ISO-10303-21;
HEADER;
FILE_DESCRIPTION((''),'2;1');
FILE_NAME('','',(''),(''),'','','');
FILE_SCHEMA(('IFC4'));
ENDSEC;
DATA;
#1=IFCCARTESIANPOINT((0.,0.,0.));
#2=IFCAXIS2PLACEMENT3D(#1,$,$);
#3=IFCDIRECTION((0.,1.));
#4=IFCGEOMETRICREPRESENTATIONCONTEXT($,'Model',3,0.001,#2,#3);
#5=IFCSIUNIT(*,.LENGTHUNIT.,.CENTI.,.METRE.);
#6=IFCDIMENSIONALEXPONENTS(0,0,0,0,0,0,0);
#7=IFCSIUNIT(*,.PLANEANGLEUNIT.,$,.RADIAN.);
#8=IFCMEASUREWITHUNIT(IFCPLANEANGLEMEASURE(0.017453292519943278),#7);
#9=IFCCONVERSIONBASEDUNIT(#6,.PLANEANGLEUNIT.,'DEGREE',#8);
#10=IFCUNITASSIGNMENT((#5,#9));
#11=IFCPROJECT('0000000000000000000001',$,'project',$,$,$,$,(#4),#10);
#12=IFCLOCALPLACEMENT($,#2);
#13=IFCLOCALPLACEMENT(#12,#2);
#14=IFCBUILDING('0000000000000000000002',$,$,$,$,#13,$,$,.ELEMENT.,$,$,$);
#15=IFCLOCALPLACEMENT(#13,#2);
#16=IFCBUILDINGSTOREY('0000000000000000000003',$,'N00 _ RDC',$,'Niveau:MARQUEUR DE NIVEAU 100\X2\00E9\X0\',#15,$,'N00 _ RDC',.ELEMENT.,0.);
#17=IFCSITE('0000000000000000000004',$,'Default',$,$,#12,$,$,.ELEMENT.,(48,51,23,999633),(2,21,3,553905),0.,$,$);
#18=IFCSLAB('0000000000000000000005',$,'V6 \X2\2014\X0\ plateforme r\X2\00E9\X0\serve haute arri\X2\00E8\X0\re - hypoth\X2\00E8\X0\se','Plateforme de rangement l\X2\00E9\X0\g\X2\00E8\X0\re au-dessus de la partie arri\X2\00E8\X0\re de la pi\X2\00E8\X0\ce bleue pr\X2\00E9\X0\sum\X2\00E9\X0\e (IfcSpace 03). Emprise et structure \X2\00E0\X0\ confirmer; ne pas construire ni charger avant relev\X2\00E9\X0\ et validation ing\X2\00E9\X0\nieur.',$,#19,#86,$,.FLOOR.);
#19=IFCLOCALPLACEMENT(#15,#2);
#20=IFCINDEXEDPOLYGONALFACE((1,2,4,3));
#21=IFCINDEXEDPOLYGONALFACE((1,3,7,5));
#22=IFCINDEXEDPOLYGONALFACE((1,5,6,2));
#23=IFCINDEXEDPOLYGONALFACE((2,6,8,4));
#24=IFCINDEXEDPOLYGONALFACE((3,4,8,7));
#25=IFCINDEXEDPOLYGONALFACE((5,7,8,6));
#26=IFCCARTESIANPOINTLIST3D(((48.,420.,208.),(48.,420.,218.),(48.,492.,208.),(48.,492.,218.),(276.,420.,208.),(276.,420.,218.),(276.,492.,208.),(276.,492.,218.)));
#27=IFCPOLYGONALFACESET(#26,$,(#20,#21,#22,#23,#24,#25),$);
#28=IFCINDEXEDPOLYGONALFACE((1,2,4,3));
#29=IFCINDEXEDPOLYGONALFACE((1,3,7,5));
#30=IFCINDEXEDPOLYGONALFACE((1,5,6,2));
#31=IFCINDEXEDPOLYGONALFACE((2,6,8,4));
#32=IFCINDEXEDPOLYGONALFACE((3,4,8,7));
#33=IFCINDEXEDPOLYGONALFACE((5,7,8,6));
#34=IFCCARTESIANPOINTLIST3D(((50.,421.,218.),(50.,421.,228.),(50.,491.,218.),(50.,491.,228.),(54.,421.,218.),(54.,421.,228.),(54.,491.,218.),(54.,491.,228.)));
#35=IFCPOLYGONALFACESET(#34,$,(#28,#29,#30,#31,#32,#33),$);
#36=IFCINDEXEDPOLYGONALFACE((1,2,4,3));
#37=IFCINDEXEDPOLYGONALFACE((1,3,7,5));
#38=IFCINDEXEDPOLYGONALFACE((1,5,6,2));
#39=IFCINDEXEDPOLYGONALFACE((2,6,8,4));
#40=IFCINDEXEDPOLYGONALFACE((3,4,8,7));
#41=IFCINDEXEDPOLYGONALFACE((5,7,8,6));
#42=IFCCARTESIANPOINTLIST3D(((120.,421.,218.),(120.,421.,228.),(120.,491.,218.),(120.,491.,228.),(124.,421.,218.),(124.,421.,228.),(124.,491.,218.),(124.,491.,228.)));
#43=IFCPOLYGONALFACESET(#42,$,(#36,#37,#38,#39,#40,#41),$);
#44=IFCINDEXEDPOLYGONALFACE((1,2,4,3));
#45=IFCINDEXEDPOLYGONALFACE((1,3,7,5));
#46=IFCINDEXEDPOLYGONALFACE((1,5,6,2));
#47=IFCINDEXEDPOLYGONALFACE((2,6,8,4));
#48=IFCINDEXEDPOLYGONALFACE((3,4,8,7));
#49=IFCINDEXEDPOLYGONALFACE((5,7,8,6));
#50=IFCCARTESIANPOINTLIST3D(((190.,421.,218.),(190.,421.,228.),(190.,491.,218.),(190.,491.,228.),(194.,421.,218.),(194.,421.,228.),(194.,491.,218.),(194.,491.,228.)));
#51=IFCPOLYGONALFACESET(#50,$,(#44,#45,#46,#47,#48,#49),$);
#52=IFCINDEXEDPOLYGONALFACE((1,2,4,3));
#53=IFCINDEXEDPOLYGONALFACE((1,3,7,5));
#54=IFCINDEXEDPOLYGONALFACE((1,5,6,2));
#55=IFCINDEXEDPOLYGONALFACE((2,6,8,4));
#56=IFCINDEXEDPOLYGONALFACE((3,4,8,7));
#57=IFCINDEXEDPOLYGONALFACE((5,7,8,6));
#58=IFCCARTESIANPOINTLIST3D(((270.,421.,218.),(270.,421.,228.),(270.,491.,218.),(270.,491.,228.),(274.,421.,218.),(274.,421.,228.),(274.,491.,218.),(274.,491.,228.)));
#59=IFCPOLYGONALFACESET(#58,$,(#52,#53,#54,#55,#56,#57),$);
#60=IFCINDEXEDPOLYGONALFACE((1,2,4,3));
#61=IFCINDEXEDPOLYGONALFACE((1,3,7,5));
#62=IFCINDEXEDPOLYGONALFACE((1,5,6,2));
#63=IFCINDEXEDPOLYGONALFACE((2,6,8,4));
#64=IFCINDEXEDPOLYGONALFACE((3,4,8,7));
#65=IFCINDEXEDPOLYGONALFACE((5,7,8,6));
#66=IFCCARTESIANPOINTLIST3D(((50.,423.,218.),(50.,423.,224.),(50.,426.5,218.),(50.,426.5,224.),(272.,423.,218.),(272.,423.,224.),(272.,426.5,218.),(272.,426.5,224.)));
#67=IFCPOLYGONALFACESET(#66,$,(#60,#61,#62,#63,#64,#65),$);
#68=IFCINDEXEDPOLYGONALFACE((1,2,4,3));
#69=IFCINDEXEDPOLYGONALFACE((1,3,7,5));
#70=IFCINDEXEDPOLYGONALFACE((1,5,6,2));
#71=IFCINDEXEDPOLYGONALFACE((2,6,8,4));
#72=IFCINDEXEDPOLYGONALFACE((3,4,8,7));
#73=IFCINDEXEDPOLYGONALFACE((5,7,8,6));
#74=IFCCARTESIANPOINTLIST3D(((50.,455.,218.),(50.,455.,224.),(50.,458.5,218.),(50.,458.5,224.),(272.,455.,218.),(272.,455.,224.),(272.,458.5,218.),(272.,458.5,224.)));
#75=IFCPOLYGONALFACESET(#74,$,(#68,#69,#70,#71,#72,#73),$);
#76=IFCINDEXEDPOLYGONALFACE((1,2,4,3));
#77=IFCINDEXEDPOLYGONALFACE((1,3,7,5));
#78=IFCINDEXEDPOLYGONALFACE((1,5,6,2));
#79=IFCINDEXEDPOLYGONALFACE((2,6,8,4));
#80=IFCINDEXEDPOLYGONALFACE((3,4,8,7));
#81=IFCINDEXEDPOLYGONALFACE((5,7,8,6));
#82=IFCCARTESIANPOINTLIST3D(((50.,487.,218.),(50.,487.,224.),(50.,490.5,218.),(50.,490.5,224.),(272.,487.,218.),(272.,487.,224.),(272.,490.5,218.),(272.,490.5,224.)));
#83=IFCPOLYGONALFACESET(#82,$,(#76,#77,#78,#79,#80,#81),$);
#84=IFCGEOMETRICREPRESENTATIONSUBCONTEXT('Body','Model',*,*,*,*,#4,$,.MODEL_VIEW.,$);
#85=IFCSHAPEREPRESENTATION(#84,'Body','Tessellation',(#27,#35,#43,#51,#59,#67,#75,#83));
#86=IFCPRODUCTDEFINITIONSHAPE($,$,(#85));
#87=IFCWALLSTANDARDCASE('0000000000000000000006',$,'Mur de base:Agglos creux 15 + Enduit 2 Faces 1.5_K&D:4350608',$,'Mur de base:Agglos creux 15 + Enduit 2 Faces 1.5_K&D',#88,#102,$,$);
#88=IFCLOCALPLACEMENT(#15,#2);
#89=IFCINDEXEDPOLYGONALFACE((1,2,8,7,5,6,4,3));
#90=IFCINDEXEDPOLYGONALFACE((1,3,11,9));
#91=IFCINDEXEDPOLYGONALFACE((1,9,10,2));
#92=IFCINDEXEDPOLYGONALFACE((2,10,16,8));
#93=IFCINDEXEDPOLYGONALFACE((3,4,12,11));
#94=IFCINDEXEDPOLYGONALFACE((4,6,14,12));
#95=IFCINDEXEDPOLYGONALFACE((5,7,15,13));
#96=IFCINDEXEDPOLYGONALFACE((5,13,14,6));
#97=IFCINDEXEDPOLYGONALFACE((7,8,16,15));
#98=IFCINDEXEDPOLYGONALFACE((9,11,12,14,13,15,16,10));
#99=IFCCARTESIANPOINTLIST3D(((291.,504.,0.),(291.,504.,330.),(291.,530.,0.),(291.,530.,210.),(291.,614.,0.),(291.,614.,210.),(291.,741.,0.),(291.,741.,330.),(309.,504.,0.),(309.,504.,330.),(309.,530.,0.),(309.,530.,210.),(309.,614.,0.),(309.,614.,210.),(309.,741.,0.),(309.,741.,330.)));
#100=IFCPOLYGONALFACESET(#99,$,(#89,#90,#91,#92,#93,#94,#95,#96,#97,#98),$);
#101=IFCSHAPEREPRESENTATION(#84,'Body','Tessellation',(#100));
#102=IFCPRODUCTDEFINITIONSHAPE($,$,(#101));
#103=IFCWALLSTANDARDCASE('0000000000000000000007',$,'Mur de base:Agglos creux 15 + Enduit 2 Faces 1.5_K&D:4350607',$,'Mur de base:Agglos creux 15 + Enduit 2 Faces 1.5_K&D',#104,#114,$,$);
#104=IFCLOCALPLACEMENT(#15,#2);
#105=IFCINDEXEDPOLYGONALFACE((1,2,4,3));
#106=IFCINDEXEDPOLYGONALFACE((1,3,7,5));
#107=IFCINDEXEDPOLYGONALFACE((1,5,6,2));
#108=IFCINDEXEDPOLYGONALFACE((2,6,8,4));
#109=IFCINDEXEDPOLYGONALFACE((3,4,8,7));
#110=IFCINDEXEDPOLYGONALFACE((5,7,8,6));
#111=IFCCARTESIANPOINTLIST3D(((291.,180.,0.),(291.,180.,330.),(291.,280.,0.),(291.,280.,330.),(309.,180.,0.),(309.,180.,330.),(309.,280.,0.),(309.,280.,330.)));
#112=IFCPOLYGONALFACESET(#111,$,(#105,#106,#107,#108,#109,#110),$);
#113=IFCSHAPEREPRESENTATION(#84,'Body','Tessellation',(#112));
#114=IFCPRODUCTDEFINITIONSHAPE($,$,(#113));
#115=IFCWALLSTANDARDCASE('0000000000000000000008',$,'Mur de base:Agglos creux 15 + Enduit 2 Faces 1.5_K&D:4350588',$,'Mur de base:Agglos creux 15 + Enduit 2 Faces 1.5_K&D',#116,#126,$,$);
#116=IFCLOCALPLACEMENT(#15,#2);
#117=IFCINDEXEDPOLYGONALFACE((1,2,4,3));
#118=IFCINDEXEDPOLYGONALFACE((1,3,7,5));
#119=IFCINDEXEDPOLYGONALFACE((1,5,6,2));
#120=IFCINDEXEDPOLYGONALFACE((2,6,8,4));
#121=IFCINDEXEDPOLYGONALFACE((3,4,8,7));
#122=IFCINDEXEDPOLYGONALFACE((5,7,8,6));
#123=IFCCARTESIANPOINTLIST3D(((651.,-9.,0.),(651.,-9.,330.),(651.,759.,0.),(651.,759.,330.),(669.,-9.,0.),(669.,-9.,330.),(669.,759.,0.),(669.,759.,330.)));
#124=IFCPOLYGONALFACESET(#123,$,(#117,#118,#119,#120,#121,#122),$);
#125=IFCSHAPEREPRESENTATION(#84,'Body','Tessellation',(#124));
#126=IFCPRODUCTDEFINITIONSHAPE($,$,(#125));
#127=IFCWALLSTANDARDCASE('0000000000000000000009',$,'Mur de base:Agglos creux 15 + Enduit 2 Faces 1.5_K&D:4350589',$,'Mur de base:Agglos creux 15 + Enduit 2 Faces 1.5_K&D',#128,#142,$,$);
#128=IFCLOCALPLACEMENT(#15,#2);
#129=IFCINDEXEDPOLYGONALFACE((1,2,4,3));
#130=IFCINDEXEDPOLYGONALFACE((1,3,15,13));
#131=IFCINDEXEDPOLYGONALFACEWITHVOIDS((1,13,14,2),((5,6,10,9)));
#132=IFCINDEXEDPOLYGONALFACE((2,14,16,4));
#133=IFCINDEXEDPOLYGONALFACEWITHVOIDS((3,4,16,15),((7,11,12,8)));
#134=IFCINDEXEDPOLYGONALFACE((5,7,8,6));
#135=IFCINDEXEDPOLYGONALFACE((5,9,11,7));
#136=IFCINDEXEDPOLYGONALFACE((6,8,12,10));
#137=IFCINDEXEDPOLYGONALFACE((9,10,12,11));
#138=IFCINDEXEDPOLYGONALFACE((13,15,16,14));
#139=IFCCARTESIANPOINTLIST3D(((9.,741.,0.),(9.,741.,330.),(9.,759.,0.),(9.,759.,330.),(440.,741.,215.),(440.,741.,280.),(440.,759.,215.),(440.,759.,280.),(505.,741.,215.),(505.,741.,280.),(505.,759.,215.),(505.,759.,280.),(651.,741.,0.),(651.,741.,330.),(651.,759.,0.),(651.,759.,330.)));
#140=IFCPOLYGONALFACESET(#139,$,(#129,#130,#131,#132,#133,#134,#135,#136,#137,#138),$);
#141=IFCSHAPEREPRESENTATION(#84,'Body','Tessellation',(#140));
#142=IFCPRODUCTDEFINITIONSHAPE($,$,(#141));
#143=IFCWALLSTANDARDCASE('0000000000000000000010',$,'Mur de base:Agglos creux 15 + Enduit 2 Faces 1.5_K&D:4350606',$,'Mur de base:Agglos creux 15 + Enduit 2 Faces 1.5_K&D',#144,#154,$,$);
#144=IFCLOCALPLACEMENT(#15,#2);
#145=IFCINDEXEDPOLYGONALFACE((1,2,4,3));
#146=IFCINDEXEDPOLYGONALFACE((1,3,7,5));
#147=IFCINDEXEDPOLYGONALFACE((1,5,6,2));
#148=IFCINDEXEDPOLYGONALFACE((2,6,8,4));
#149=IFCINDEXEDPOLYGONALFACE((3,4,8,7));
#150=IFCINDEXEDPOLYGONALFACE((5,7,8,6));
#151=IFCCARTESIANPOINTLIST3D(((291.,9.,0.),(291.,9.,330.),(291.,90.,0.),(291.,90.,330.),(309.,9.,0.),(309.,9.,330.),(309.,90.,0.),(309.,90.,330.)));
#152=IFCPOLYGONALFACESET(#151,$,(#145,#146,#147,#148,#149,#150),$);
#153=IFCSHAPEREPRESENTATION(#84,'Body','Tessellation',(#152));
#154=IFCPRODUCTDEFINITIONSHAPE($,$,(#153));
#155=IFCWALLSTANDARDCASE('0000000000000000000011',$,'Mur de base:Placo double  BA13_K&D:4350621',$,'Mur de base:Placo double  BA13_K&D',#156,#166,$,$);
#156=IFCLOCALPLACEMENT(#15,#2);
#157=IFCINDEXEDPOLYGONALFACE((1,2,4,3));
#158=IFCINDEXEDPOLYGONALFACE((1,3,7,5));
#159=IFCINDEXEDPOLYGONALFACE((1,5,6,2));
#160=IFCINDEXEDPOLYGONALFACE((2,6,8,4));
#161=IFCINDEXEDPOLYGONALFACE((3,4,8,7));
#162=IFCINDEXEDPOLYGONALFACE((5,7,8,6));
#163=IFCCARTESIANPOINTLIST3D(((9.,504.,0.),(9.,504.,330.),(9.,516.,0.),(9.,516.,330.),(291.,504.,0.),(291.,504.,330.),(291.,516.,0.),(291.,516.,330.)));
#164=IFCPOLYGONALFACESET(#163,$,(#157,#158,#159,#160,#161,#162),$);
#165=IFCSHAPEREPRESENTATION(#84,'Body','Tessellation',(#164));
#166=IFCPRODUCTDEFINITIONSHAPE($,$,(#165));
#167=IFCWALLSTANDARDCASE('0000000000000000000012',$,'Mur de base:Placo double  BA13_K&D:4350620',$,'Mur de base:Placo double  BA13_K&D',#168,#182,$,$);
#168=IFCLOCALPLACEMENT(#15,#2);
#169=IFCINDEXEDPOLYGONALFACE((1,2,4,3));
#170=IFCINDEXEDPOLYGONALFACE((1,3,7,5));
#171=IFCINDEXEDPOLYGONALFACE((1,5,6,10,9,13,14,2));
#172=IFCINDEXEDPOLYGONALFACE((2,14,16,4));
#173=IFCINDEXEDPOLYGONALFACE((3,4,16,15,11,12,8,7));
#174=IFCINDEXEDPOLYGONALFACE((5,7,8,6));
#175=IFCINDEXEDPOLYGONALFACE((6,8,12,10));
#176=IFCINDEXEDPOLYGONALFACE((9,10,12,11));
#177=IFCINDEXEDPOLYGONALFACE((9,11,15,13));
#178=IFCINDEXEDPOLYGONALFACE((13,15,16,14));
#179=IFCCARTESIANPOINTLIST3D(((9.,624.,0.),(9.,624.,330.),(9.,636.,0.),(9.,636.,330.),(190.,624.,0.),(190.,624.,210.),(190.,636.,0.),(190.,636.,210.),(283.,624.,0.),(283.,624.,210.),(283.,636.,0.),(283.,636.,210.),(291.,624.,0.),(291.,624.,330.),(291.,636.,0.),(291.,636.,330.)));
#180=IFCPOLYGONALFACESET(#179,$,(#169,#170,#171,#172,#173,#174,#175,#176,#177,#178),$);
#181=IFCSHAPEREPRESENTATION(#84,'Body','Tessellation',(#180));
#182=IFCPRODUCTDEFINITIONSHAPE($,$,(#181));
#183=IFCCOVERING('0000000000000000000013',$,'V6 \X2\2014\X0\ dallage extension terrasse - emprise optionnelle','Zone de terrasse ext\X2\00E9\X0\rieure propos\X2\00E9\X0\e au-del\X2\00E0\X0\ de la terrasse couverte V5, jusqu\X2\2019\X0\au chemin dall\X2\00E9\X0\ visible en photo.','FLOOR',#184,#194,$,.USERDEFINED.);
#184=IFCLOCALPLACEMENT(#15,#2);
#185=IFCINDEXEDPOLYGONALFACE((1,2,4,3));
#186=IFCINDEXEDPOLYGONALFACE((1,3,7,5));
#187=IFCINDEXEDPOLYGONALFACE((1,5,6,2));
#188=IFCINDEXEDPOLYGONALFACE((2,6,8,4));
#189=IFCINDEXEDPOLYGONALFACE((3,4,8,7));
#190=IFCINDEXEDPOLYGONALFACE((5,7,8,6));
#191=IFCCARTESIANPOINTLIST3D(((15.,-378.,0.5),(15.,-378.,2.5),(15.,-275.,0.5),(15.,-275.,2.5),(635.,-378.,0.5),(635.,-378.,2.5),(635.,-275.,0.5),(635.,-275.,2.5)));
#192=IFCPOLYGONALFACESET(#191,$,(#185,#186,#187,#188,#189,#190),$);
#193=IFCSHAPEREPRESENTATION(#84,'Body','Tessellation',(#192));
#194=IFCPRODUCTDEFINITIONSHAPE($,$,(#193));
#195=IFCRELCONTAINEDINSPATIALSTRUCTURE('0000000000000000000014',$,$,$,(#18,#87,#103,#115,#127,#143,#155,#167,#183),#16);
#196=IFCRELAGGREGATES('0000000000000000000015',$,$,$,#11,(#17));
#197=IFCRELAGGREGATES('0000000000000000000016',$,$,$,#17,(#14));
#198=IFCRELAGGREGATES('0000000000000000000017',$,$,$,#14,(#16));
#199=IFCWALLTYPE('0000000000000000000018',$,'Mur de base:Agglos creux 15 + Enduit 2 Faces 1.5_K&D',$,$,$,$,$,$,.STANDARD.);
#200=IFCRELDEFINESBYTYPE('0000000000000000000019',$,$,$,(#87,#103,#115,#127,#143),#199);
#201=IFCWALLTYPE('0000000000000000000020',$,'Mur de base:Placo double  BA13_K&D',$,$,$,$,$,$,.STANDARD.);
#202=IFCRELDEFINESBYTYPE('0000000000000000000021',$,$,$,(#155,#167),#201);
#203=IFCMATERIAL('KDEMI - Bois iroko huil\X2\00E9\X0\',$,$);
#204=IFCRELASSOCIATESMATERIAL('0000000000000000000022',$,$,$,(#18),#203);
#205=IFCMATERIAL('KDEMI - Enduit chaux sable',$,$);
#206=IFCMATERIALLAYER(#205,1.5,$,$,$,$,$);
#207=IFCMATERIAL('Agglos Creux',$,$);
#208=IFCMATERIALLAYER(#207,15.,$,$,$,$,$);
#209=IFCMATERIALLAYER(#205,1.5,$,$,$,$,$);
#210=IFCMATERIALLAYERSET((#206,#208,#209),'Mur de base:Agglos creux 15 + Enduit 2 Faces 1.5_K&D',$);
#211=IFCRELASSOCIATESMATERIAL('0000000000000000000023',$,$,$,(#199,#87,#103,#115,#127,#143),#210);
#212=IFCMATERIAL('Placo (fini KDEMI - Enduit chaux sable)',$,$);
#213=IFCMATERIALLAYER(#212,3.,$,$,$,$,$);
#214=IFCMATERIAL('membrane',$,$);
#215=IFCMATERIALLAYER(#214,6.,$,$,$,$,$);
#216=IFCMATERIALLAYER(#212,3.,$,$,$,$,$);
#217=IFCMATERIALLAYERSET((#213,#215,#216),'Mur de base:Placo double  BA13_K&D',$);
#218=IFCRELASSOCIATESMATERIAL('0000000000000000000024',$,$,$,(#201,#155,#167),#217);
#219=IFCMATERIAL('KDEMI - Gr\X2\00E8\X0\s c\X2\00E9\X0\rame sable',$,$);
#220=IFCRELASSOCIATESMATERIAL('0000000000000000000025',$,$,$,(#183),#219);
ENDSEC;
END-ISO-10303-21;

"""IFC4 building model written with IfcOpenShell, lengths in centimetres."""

from ifc_helpers import new_model, entity, si_unit, converted_unit, direction, frame, frame_2d, origin, origin_with_axes, place, context, subcontext, project, spatial, rectangle, extrude, material, layer, layer_set, layer_usage, type_object, element, save


model = new_model("IFC4")

# Units and contexts
model_context = context("Model", 3, precision=0.001, world=origin(), true_north=direction((0.0, 1.0)))
body_context = subcontext(model_context, "Body", "Model", "MODEL_VIEW")
ifc_project = project(units=[si_unit("LENGTHUNIT", "METRE", prefix="CENTI"), converted_unit("PLANEANGLEUNIT", "DEGREE", entity("IfcPlaneAngleMeasure", 0.017453292519943278), si_unit("PLANEANGLEUNIT", "RADIAN"), dimensions=[0, 0, 0, 0, 0, 0, 0])], contexts=[model_context])

# Site, building, storey
site_placement = place(None, origin())
site = spatial("IfcSite", under=ifc_project, at=site_placement, Name="Default", CompositionType="ELEMENT", RefLatitude=(48, 51, 23, 999633), RefLongitude=(2, 21, 3, 553905), RefElevation=0.0)
building_placement = place(site_placement, origin())
building = spatial("IfcBuilding", under=site, at=building_placement, CompositionType="ELEMENT")
storey_placement = place(building_placement, origin())
storey = spatial("IfcBuildingStorey", under=building, at=storey_placement, Name="N00 _ RDC", ObjectType="Niveau:MARQUEUR DE NIVEAU 100é", LongName="N00 _ RDC", CompositionType="ELEMENT", Elevation=0.0)

# Slab
ifc_material_1 = material(Name="KDEMI - Bois iroko huilé")
slab_placement = place(storey_placement, origin_with_axes())
element("IfcSlab", 1, at=slab_placement, inside=storey, material=ifc_material_1, Name="V6 — plateforme réserve haute arrière - hypothèse", Description="Plateforme de rangement légère au-dessus de la partie arrière de la pièce bleue présumée (IfcSpace 03). Emprise et structure à confirmer; ne pas construire ni charger avant relevé et validation ingénieur.", PredefinedType="FLOOR", context=body_context, shape_type="SweptSolid", body=[
    extrude(rectangle(XDim=228.0, YDim=72.0, at=frame_2d((162.0, 456.0))), frame((0.0, 0.0, 208.0)), (0.0, 0.0, 1.0), 10.0),
    extrude(rectangle(XDim=4.0, YDim=70.0, at=frame_2d((52.0, 456.0))), frame((0.0, 0.0, 218.0)), (0.0, 0.0, 1.0), 10.0),
    extrude(rectangle(XDim=4.0, YDim=70.0, at=frame_2d((122.0, 456.0))), frame((0.0, 0.0, 218.0)), (0.0, 0.0, 1.0), 10.0),
    extrude(rectangle(XDim=4.0, YDim=70.0, at=frame_2d((192.0, 456.0))), frame((0.0, 0.0, 218.0)), (0.0, 0.0, 1.0), 10.0),
    extrude(rectangle(XDim=4.0, YDim=70.0, at=frame_2d((272.0, 456.0))), frame((0.0, 0.0, 218.0)), (0.0, 0.0, 1.0), 10.0),
    extrude(rectangle(XDim=222.0, YDim=3.5, at=frame_2d((161.0, 424.75))), frame((0.0, 0.0, 218.0)), (0.0, 0.0, 1.0), 6.0),
    extrude(rectangle(XDim=222.0, YDim=3.5, at=frame_2d((161.0, 456.75))), frame((0.0, 0.0, 218.0)), (0.0, 0.0, 1.0), 6.0),
    extrude(rectangle(XDim=222.0, YDim=3.5, at=frame_2d((161.0, 488.75))), frame((0.0, 0.0, 218.0)), (0.0, 0.0, 1.0), 6.0),
])

# Wall, opening
ifc_material_2 = material(Name="KDEMI - Enduit chaux sable")
ifc_layer_1 = layer(ifc_material_2, 1.5)
ifc_material_3 = material(Name="Agglos Creux")
ifc_layer_2 = layer(ifc_material_3, 15.0)
ifc_layer_3 = layer(ifc_material_2, 1.5)
ifc_layer_set_1 = layer_set([ifc_layer_1, ifc_layer_2, ifc_layer_3], Name="Mur de base:Agglos creux 15 + Enduit 2 Faces 1.5_K&D")
ifc_layer_usage_1 = layer_usage(ifc_layer_set_1, "AXIS2", "POSITIVE", -9.0)
wall_type_1 = type_object("IfcWallType", Name="Mur de base:Agglos creux 15 + Enduit 2 Faces 1.5_K&D", PredefinedType="STANDARD", material=ifc_layer_set_1)
wall_1_placement = place(storey_placement, frame((300.0, 504.0, 0.0), z_axis=(0.0, 0.0, 1.0), x_axis=(0.0, 1.0, 0.0)))
wall_1 = element("IfcWallStandardCase", 2, at=wall_1_placement, inside=storey, type_object=wall_type_1, material=ifc_layer_usage_1, Name="Mur de base:Agglos creux 15 + Enduit 2 Faces 1.5_K&D:4350608", ObjectType="Mur de base:Agglos creux 15 + Enduit 2 Faces 1.5_K&D", context=body_context, shape_type="SweptSolid", body=[
    extrude(rectangle(XDim=237.0, YDim=18.0, at=frame_2d((118.5, 0.0), x_axis=(1.0, 0.0))), origin(), (0.0, 0.0, 1.0), 330.0),
])
opening_1_placement = place(wall_1_placement, frame((-504.0, 300.0, 0.0), z_axis=(0.0, 0.0, 1.0), x_axis=(0.0, -1.0, 0.0)))
element("IfcOpeningElement", 3, at=opening_1_placement, inside=storey, cuts=wall_1, context=body_context, shape_type="SweptSolid", body=[
    extrude(rectangle(XDim=22.0, YDim=84.0, at=frame_2d((300.0, 572.0))), origin(), (0.0, 0.0, 1.0), 210.0),
])

# Walls
ifc_layer_usage_2 = layer_usage(ifc_layer_set_1, "AXIS2", "NEGATIVE", 9.0)
wall_2_placement = place(storey_placement, frame((300.0, 180.0, 0.0), z_axis=(0.0, 0.0, 1.0), x_axis=(0.0, 1.0, 0.0)))
element("IfcWallStandardCase", 4, at=wall_2_placement, inside=storey, type_object=wall_type_1, material=ifc_layer_usage_2, Name="Mur de base:Agglos creux 15 + Enduit 2 Faces 1.5_K&D:4350607", ObjectType="Mur de base:Agglos creux 15 + Enduit 2 Faces 1.5_K&D", context=body_context, shape_type="SweptSolid", body=[
    extrude(rectangle(XDim=100.0, YDim=18.0, at=frame_2d((50.0, 0.0), x_axis=(-1.0, 0.0))), origin(), (0.0, 0.0, 1.0), 330.0),
])
ifc_layer_usage_3 = layer_usage(ifc_layer_set_1, "AXIS2", "NEGATIVE", 9.0)
wall_3_placement = place(storey_placement, frame((660.0, -9.0, 0.0), z_axis=(0.0, 0.0, 1.0), x_axis=(0.0, 1.0, 0.0)))
element("IfcWallStandardCase", 5, at=wall_3_placement, inside=storey, type_object=wall_type_1, material=ifc_layer_usage_3, Name="Mur de base:Agglos creux 15 + Enduit 2 Faces 1.5_K&D:4350588", ObjectType="Mur de base:Agglos creux 15 + Enduit 2 Faces 1.5_K&D", context=body_context, shape_type="SweptSolid", body=[
    extrude(rectangle(XDim=768.0, YDim=18.0, at=frame_2d((384.0, 0.0), x_axis=(-1.0, 0.0))), origin(), (0.0, 0.0, 1.0), 330.0),
])

# Wall, opening
ifc_layer_usage_4 = layer_usage(ifc_layer_set_1, "AXIS2", "NEGATIVE", 9.0)
wall_4_placement = place(storey_placement, frame((9.0, 750.0, 0.0)))
wall_4 = element("IfcWallStandardCase", 6, at=wall_4_placement, inside=storey, type_object=wall_type_1, material=ifc_layer_usage_4, Name="Mur de base:Agglos creux 15 + Enduit 2 Faces 1.5_K&D:4350589", ObjectType="Mur de base:Agglos creux 15 + Enduit 2 Faces 1.5_K&D", context=body_context, shape_type="SweptSolid", body=[
    extrude(rectangle(XDim=642.0, YDim=18.0, at=frame_2d((321.0, 0.0), x_axis=(-1.0, 0.0))), origin(), (0.0, 0.0, 1.0), 330.0),
])
opening_2_placement = place(wall_4_placement, origin())
element("IfcOpeningElement", 7, at=opening_2_placement, cuts=wall_4, ObjectType="Opening", context=body_context, shape_type="SweptSolid", body=[
    extrude(rectangle(XDim=65.0, YDim=65.0, at=frame_2d((0.0, 0.0), x_axis=(1.0, 0.0))), frame((463.5, -9.0, 247.5), z_axis=(0.0, 1.0, 0.0), x_axis=(0.0, 0.0, -1.0)), (0.0, 0.0, 1.0), 18.0),
])

# Walls
ifc_layer_usage_5 = layer_usage(ifc_layer_set_1, "AXIS2", "NEGATIVE", 9.0)
wall_5_placement = place(storey_placement, frame((300.0, 9.0, 0.0), z_axis=(0.0, 0.0, 1.0), x_axis=(0.0, 1.0, 0.0)))
element("IfcWallStandardCase", 8, at=wall_5_placement, inside=storey, type_object=wall_type_1, material=ifc_layer_usage_5, Name="Mur de base:Agglos creux 15 + Enduit 2 Faces 1.5_K&D:4350606", ObjectType="Mur de base:Agglos creux 15 + Enduit 2 Faces 1.5_K&D", context=body_context, shape_type="SweptSolid", body=[
    extrude(rectangle(XDim=81.0, YDim=18.0, at=frame_2d((40.5, 0.0), x_axis=(-1.0, 0.0))), origin(), (0.0, 0.0, 1.0), 330.0),
])
ifc_material_4 = material(Name="Placo (fini KDEMI - Enduit chaux sable)")
ifc_layer_4 = layer(ifc_material_4, 3.0)
ifc_material_5 = material(Name="membrane")
ifc_layer_5 = layer(ifc_material_5, 6.0)
ifc_layer_6 = layer(ifc_material_4, 3.0)
ifc_layer_set_2 = layer_set([ifc_layer_4, ifc_layer_5, ifc_layer_6], Name="Mur de base:Placo double  BA13_K&D")
ifc_layer_usage_6 = layer_usage(ifc_layer_set_2, "AXIS2", "POSITIVE", -6.0)
wall_type_2 = type_object("IfcWallType", Name="Mur de base:Placo double  BA13_K&D", PredefinedType="STANDARD", material=ifc_layer_set_2)
wall_6_placement = place(storey_placement, frame((9.0, 510.0, 0.0)))
element("IfcWallStandardCase", 9, at=wall_6_placement, inside=storey, type_object=wall_type_2, material=ifc_layer_usage_6, Name="Mur de base:Placo double  BA13_K&D:4350621", ObjectType="Mur de base:Placo double  BA13_K&D", context=body_context, shape_type="SweptSolid", body=[
    extrude(rectangle(XDim=282.0, YDim=12.0, at=frame_2d((141.0, 0.0), x_axis=(-1.0, 0.0))), origin(), (0.0, 0.0, 1.0), 330.0),
])

# Wall, opening
ifc_layer_usage_7 = layer_usage(ifc_layer_set_2, "AXIS2", "NEGATIVE", 6.0)
wall_7_placement = place(storey_placement, frame((9.0, 630.0, 0.0)))
wall_7 = element("IfcWallStandardCase", 10, at=wall_7_placement, inside=storey, type_object=wall_type_2, material=ifc_layer_usage_7, Name="Mur de base:Placo double  BA13_K&D:4350620", ObjectType="Mur de base:Placo double  BA13_K&D", context=body_context, shape_type="SweptSolid", body=[
    extrude(rectangle(XDim=282.0, YDim=12.0, at=frame_2d((141.0, 0.0), x_axis=(-1.0, 0.0))), origin(), (0.0, 0.0, 1.0), 330.0),
])
opening_3_placement = place(wall_7_placement, frame((-9.0, -630.0, 0.0), z_axis=(0.0, 0.0, 1.0), x_axis=(1.0, 0.0, 0.0)))
element("IfcOpeningElement", 11, at=opening_3_placement, inside=storey, cuts=wall_7, context=body_context, shape_type="SweptSolid", body=[
    extrude(rectangle(XDim=93.0, YDim=16.0, at=frame_2d((236.5, 630.0))), origin(), (0.0, 0.0, 1.0), 210.0),
])

# Covering
ifc_material_6 = material(Name="KDEMI - Grès cérame sable")
covering_placement = place(storey_placement, origin_with_axes())
element("IfcCovering", 12, at=covering_placement, inside=storey, material=ifc_material_6, Name="V6 — dallage extension terrasse - emprise optionnelle", Description="Zone de terrasse extérieure proposée au-delà de la terrasse couverte V5, jusqu’au chemin dallé visible en photo.", ObjectType="FLOOR", PredefinedType="USERDEFINED", context=body_context, shape_type="SweptSolid", body=[
    extrude(rectangle(XDim=620.0, YDim=103.0, at=frame_2d((325.0, -326.5))), frame((0.0, 0.0, 0.5)), (0.0, 0.0, 1.0), 2.0),
])

save(model, "model.ifc")
